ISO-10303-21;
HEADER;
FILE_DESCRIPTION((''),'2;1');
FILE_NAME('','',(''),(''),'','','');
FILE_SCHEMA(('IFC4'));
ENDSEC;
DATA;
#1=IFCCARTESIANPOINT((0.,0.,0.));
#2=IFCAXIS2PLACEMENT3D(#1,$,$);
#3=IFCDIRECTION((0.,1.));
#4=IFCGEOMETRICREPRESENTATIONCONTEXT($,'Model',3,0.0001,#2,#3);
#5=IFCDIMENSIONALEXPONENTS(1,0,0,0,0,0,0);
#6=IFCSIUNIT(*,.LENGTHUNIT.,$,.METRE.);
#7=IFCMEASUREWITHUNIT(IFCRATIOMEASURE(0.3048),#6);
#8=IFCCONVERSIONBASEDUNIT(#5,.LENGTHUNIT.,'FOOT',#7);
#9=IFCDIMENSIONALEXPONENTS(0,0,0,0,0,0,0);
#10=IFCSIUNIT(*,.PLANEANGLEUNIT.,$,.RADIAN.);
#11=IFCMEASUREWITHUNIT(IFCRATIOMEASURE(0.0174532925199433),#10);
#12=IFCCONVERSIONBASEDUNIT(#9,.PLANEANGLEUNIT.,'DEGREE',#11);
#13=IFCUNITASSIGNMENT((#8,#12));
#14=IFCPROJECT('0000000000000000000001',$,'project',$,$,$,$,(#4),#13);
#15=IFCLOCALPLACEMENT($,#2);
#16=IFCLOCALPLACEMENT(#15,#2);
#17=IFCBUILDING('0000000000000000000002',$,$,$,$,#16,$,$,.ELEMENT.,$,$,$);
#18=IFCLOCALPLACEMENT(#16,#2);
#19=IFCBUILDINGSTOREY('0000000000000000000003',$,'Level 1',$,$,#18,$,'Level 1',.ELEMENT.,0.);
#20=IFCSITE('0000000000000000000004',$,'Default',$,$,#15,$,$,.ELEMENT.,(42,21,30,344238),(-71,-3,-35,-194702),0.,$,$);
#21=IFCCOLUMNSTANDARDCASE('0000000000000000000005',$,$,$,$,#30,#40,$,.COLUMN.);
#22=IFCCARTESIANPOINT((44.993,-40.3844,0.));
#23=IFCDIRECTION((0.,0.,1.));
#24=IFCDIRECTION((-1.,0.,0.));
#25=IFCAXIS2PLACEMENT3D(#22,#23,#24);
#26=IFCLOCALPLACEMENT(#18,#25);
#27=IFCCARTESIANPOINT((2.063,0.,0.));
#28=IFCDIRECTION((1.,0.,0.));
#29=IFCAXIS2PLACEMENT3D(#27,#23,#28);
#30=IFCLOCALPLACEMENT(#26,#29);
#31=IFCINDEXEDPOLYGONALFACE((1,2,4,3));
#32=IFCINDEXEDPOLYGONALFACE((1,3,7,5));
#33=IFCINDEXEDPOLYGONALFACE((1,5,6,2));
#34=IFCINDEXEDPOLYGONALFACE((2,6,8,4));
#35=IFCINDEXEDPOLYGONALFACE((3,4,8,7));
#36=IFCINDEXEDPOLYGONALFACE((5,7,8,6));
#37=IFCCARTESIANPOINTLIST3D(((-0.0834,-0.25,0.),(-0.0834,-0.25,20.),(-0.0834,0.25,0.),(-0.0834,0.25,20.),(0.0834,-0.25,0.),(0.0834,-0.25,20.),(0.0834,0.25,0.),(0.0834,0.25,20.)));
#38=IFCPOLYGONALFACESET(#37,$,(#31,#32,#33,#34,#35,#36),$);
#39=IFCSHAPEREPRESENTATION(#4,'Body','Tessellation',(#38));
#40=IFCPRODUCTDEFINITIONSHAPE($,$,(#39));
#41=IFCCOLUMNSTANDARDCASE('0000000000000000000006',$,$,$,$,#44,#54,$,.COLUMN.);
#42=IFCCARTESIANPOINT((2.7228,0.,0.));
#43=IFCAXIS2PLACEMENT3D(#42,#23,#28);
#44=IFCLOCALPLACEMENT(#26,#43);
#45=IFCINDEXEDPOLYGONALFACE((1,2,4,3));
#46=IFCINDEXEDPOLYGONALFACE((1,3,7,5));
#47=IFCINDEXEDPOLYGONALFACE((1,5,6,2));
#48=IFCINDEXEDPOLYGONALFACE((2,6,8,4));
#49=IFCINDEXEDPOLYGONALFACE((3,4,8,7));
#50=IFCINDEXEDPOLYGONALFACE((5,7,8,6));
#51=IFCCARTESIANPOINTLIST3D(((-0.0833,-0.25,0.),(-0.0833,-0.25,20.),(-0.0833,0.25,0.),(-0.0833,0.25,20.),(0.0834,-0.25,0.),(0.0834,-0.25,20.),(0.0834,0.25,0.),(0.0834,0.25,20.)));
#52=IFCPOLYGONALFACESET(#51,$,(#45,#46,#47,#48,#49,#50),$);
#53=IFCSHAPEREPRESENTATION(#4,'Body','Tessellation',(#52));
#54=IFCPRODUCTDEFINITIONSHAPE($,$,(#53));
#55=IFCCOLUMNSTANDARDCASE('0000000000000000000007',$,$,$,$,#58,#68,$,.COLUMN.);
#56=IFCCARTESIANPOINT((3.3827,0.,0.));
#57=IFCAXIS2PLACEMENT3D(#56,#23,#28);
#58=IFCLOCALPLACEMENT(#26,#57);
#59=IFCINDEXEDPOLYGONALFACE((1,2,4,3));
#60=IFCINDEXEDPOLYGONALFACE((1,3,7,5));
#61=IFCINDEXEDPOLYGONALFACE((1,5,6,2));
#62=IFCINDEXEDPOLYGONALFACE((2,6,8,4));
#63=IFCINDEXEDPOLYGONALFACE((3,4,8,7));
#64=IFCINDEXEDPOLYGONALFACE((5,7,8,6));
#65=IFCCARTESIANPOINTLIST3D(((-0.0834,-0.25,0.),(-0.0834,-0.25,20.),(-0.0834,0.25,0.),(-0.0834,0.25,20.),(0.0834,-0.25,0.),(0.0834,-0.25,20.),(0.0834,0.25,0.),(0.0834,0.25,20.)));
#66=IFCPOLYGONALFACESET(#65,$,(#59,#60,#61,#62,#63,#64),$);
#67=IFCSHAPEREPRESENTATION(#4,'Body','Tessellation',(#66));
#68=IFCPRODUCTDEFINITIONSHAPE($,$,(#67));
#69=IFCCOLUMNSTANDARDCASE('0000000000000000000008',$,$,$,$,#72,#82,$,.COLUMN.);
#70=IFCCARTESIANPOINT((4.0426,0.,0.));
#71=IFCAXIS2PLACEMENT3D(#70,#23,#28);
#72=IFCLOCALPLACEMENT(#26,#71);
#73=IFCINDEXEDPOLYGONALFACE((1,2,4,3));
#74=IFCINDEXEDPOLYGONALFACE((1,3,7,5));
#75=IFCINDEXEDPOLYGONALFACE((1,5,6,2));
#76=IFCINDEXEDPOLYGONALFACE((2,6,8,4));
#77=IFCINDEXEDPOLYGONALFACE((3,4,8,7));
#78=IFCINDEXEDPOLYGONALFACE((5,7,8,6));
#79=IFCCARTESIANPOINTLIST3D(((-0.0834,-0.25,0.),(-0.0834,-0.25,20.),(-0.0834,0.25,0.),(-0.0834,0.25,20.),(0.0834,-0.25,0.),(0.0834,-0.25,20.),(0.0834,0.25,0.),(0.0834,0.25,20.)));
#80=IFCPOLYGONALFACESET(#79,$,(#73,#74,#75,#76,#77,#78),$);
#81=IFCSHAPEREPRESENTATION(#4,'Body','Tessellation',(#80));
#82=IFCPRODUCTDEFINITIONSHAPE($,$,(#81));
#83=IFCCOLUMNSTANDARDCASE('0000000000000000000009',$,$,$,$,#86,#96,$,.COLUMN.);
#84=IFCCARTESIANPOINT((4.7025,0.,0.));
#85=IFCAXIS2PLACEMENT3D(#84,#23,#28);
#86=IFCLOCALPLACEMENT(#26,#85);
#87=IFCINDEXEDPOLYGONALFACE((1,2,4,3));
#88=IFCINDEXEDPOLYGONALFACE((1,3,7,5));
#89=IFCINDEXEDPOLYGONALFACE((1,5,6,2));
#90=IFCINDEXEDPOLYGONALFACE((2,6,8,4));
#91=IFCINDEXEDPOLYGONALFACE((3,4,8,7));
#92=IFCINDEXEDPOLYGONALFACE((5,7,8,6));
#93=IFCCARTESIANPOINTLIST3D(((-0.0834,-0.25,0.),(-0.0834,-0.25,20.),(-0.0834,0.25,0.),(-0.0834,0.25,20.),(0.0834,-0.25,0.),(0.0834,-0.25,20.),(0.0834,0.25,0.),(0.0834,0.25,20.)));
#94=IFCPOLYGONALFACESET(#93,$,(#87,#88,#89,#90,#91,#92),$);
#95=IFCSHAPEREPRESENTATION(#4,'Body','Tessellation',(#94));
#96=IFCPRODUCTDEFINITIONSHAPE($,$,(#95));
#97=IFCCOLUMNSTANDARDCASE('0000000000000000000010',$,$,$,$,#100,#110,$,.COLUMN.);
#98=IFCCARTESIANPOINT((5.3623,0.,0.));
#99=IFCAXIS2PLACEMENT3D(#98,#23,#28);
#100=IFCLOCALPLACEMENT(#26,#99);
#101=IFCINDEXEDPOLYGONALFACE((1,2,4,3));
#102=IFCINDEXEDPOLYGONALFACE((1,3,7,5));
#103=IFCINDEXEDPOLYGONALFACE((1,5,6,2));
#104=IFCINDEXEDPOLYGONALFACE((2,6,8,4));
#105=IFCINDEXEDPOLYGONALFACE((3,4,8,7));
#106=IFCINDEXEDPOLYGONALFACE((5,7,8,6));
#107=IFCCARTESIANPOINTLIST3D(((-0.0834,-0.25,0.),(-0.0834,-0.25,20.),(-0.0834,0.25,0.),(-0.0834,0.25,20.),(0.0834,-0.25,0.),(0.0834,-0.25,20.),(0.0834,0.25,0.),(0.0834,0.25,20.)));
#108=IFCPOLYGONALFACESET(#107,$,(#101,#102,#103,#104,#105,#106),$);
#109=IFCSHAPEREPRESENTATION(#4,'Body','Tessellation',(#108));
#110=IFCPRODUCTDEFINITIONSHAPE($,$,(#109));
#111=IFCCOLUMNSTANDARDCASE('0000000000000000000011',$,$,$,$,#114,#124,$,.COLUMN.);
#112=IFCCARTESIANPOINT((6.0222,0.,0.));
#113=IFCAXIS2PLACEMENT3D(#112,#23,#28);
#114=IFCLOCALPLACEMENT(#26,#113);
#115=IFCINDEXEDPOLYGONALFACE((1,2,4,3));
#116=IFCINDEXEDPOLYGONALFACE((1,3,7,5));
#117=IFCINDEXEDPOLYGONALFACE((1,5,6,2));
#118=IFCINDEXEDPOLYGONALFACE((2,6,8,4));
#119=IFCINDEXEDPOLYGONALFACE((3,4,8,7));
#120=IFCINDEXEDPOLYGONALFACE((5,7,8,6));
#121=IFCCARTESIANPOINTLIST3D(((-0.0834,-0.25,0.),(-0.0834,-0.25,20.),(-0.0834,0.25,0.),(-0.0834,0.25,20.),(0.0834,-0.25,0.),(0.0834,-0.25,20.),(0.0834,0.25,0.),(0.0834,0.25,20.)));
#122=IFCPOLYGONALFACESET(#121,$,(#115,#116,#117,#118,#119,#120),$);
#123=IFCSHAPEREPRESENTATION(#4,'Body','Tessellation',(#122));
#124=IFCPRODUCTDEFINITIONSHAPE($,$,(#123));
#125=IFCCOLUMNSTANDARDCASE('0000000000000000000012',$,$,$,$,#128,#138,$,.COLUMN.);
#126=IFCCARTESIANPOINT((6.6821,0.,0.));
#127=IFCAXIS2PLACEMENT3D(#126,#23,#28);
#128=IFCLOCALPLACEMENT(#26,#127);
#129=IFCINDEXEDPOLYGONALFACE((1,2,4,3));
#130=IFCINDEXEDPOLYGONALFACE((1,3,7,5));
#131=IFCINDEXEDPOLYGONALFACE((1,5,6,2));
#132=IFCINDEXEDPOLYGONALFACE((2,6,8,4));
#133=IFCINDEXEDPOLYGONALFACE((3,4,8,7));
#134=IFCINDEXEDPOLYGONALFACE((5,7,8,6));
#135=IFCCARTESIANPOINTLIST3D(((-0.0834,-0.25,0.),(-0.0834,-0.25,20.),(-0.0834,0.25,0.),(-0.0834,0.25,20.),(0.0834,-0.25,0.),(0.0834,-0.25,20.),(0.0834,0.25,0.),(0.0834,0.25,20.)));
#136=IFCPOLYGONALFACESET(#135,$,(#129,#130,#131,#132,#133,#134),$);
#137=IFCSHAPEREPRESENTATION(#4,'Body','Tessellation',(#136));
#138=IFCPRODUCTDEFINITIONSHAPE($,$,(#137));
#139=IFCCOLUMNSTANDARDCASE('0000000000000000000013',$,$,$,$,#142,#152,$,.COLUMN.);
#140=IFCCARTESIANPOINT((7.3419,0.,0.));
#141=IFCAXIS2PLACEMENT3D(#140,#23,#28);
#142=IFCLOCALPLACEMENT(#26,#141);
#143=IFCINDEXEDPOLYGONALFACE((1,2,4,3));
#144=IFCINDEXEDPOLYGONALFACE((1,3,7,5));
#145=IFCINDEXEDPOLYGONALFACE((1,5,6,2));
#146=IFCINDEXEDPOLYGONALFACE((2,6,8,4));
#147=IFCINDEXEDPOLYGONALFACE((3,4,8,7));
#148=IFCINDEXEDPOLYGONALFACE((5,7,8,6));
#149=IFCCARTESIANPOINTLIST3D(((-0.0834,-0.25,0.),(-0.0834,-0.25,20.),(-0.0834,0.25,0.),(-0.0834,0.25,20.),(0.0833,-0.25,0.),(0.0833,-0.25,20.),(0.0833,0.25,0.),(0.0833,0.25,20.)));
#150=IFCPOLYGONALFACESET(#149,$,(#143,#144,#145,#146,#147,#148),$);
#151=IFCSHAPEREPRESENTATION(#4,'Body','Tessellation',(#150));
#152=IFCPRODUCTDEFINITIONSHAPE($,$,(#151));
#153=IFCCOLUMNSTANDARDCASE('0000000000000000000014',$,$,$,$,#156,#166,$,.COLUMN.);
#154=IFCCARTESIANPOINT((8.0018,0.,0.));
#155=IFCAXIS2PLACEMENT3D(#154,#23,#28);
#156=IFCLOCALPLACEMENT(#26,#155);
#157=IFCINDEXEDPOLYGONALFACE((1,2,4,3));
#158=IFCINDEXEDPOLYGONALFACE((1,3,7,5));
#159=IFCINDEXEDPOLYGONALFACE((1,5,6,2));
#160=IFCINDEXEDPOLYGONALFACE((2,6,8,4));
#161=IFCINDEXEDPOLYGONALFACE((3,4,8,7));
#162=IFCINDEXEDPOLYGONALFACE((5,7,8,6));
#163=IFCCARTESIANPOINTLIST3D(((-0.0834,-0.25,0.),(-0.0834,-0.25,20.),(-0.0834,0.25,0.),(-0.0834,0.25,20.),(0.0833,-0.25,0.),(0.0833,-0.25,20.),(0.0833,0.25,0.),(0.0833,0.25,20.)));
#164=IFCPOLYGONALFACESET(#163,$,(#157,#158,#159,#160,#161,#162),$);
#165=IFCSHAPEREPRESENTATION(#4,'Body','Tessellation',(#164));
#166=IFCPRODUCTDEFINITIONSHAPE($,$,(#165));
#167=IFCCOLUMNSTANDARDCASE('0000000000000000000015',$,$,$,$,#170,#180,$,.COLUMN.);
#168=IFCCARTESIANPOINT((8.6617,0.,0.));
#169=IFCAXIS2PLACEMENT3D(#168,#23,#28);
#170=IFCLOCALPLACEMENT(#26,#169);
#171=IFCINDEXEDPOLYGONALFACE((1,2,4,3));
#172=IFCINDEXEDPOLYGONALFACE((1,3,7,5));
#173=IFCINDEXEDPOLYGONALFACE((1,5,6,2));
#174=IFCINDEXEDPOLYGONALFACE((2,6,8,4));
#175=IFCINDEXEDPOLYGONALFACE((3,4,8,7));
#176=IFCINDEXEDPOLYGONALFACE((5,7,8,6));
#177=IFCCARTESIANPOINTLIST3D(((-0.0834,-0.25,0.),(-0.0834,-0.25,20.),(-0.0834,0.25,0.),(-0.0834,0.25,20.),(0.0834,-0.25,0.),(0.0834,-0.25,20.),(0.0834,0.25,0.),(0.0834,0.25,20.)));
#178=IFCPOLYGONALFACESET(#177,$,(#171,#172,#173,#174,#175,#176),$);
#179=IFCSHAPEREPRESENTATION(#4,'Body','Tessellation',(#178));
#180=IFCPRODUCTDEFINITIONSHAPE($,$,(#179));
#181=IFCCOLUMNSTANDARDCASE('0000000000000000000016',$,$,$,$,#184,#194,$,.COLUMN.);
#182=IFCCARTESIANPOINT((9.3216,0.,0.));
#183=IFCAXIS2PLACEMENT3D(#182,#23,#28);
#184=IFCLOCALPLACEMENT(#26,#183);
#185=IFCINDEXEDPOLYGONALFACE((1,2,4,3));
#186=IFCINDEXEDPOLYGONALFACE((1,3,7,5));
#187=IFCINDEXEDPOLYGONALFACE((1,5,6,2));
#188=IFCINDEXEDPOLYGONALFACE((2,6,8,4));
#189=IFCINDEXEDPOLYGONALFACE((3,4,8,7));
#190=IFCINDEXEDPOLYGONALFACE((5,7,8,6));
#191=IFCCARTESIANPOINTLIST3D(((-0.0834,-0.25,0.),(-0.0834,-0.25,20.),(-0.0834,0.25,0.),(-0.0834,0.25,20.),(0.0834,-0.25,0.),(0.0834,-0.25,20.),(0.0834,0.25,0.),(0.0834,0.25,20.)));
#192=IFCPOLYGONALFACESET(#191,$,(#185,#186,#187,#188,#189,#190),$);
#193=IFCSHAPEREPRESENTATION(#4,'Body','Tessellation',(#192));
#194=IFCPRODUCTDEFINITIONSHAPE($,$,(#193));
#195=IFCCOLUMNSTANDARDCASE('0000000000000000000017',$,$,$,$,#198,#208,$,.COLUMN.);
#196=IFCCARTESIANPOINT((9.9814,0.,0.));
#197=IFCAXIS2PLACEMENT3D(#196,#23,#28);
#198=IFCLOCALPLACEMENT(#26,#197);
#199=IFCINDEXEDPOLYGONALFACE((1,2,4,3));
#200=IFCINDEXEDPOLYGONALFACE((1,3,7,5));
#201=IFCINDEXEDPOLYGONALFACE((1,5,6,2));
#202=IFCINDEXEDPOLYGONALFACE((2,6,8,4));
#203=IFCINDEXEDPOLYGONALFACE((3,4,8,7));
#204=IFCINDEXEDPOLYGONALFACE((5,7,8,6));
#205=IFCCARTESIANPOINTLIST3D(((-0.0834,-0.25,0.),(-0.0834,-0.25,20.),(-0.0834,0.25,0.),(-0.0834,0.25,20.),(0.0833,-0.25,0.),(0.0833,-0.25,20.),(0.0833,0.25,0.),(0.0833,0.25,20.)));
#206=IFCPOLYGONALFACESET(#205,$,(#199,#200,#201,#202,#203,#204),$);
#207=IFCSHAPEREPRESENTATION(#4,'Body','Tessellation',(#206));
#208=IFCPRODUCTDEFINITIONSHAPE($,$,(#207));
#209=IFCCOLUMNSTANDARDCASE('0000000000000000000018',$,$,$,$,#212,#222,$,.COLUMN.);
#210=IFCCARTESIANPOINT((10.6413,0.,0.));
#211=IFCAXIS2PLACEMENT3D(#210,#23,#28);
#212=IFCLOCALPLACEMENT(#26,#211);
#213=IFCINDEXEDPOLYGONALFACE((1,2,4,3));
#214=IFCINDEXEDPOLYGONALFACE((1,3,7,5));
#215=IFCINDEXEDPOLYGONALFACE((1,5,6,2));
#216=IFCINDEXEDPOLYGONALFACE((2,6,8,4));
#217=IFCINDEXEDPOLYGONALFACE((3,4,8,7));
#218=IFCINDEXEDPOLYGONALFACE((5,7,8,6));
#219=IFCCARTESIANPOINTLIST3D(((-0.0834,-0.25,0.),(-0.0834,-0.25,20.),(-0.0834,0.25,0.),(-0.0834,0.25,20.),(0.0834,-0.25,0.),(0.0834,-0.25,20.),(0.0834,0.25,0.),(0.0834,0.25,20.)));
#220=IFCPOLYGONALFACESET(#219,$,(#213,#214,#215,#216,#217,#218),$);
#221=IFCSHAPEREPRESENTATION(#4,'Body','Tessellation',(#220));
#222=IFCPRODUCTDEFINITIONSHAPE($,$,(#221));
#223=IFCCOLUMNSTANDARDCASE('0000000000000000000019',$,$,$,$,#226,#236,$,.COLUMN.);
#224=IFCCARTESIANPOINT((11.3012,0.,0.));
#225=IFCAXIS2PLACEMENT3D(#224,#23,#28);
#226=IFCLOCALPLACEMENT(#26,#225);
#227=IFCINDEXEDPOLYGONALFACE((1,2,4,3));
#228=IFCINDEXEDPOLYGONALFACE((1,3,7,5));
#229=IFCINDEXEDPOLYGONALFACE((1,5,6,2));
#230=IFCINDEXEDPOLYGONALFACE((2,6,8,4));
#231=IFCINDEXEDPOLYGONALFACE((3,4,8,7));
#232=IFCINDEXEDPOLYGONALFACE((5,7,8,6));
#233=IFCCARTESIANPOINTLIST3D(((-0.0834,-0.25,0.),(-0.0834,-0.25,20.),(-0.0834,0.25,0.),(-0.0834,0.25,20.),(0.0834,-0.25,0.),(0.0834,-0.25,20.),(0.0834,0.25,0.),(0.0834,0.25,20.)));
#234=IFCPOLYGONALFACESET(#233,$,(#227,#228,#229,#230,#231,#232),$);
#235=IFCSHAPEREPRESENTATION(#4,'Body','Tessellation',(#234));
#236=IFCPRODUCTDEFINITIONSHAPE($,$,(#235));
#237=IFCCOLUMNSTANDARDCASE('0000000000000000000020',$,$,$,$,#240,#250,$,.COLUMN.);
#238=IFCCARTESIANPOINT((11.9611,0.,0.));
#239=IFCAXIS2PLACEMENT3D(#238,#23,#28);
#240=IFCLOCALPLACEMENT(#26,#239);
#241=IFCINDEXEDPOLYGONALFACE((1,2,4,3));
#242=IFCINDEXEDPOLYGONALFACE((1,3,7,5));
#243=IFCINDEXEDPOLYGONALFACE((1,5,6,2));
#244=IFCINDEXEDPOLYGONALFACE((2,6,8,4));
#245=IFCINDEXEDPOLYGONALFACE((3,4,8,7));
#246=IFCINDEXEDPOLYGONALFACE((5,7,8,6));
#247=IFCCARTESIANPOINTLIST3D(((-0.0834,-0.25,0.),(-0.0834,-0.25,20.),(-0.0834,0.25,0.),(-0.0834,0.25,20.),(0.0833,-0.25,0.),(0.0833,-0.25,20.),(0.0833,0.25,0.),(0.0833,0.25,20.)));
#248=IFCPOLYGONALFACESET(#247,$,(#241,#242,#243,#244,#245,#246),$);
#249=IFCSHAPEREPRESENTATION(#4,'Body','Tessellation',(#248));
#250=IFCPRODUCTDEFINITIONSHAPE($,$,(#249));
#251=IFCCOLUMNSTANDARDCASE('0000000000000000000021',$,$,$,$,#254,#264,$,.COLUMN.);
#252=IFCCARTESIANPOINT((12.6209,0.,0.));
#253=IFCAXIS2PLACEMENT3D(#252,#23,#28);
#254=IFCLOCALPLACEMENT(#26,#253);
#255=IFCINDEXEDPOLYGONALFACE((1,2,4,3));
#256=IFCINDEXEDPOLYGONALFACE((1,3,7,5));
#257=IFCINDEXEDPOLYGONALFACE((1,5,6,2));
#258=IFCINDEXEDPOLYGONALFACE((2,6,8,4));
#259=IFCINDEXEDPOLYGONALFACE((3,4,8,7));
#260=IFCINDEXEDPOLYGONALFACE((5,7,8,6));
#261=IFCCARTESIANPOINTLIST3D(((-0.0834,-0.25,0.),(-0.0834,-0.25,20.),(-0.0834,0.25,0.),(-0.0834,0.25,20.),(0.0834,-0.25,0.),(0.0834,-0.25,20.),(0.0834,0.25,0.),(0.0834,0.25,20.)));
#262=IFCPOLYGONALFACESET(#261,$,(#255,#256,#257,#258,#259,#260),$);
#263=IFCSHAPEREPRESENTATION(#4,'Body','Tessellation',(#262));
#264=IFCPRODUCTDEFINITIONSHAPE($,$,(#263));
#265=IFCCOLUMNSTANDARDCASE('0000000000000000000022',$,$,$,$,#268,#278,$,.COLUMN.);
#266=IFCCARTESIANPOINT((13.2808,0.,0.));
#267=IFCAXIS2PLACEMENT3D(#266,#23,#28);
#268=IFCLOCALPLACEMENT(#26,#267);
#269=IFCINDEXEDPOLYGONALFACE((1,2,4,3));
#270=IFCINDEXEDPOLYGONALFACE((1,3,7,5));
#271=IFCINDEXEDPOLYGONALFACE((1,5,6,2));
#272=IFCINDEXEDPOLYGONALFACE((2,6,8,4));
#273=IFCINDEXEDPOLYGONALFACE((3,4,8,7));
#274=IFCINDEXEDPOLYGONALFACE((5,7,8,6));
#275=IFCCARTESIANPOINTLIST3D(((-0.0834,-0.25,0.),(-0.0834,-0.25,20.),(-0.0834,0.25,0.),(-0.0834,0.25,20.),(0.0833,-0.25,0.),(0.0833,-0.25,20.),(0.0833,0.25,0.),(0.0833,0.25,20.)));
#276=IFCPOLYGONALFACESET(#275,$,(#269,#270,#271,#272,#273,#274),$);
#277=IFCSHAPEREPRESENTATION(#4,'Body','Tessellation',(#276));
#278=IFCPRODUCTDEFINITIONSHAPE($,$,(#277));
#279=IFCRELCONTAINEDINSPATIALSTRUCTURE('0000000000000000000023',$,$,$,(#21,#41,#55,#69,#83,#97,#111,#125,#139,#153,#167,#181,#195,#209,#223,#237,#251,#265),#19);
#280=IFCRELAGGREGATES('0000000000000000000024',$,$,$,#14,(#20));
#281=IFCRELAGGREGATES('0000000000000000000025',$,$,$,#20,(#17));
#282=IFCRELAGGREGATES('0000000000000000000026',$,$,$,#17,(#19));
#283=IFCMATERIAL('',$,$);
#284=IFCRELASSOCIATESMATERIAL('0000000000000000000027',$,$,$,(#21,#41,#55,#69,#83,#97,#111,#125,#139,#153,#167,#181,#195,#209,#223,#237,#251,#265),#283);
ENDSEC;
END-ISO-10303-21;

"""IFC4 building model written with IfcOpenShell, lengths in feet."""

from ifc_helpers import new_model, entity, si_unit, converted_unit, direction, frame, origin, place, context, project, spatial, rectangle, extrude, material, element, save


model = new_model("IFC4")

# Units and contexts
model_context = context("Model", 3, precision=0.0001, world=origin(), true_north=direction((0.0, 1.0)))
ifc_project = project(units=[converted_unit("LENGTHUNIT", "FOOT", entity("IfcRatioMeasure", 0.3048), si_unit("LENGTHUNIT", "METRE"), dimensions=[1, 0, 0, 0, 0, 0, 0]), converted_unit("PLANEANGLEUNIT", "DEGREE", entity("IfcRatioMeasure", 0.0174532925199433), si_unit("PLANEANGLEUNIT", "RADIAN"), dimensions=[0, 0, 0, 0, 0, 0, 0])], contexts=[model_context])

# Site, building, storey
site_placement = place(None, origin())
site = spatial("IfcSite", under=ifc_project, at=site_placement, Name="Default", CompositionType="ELEMENT", RefLatitude=(42, 21, 30, 344238), RefLongitude=(-71, -3, -35, -194702), RefElevation=0.0)
building_placement = place(site_placement, origin())
building = spatial("IfcBuilding", under=site, at=building_placement, CompositionType="ELEMENT")
storey_placement = place(building_placement, origin())
storey = spatial("IfcBuildingStorey", under=building, at=storey_placement, Name="Level 1", LongName="Level 1", CompositionType="ELEMENT", Elevation=0.0)

# Columns
ifc_material = material(Name="")
placement = place(storey_placement, frame((44.993, -40.3844, 0.0), z_axis=(0.0, 0.0, 1.0), x_axis=(-1.0, 0.0, 0.0)))
for number, where, z_axis, x_axis in (
    (1, (2.063, 0.0, 0.0), (0.0, 0.0, 1.0), (1.0, 0.0, 0.0)),
    (2, (2.7228, 0.0, 0.0), (0.0, 0.0, 1.0), (1.0, 0.0, 0.0)),
    (3, (3.3827, 0.0, 0.0), (0.0, 0.0, 1.0), (1.0, 0.0, 0.0)),
    (4, (4.0426, 0.0, 0.0), (0.0, 0.0, 1.0), (1.0, 0.0, 0.0)),
    (5, (4.7025, 0.0, 0.0), (0.0, 0.0, 1.0), (1.0, 0.0, 0.0)),
    (6, (5.3623, 0.0, 0.0), (0.0, 0.0, 1.0), (1.0, 0.0, 0.0)),
    (7, (6.0222, 0.0, 0.0), (0.0, 0.0, 1.0), (1.0, 0.0, 0.0)),
    (8, (6.6821, 0.0, 0.0), (0.0, 0.0, 1.0), (1.0, 0.0, 0.0)),
    (9, (7.3419, 0.0, 0.0), (0.0, 0.0, 1.0), (1.0, 0.0, 0.0)),
    (10, (8.0018, 0.0, 0.0), (0.0, 0.0, 1.0), (1.0, 0.0, 0.0)),
    (11, (8.6617, 0.0, 0.0), (0.0, 0.0, 1.0), (1.0, 0.0, 0.0)),
    (12, (9.3216, 0.0, 0.0), (0.0, 0.0, 1.0), (1.0, 0.0, 0.0)),
    (13, (9.9814, 0.0, 0.0), (0.0, 0.0, 1.0), (1.0, 0.0, 0.0)),
    (14, (10.6413, 0.0, 0.0), (0.0, 0.0, 1.0), (1.0, 0.0, 0.0)),
    (15, (11.3012, 0.0, 0.0), (0.0, 0.0, 1.0), (1.0, 0.0, 0.0)),
    (16, (11.9611, 0.0, 0.0), (0.0, 0.0, 1.0), (1.0, 0.0, 0.0)),
    (17, (12.6209, 0.0, 0.0), (0.0, 0.0, 1.0), (1.0, 0.0, 0.0)),
    (18, (13.2808, 0.0, 0.0), (0.0, 0.0, 1.0), (1.0, 0.0, 0.0)),
):
    element("IfcColumnStandardCase", number, at=place(placement, frame(where, z_axis=z_axis, x_axis=x_axis)), inside=storey, material=ifc_material, PredefinedType="COLUMN", context=model_context, shape_type="SweptSolid", body=[
        extrude(rectangle(XDim=0.1667, YDim=0.5), origin(), (0.0, 0.0, 1.0), 20.0),
    ])

save(model, "model.ifc")
